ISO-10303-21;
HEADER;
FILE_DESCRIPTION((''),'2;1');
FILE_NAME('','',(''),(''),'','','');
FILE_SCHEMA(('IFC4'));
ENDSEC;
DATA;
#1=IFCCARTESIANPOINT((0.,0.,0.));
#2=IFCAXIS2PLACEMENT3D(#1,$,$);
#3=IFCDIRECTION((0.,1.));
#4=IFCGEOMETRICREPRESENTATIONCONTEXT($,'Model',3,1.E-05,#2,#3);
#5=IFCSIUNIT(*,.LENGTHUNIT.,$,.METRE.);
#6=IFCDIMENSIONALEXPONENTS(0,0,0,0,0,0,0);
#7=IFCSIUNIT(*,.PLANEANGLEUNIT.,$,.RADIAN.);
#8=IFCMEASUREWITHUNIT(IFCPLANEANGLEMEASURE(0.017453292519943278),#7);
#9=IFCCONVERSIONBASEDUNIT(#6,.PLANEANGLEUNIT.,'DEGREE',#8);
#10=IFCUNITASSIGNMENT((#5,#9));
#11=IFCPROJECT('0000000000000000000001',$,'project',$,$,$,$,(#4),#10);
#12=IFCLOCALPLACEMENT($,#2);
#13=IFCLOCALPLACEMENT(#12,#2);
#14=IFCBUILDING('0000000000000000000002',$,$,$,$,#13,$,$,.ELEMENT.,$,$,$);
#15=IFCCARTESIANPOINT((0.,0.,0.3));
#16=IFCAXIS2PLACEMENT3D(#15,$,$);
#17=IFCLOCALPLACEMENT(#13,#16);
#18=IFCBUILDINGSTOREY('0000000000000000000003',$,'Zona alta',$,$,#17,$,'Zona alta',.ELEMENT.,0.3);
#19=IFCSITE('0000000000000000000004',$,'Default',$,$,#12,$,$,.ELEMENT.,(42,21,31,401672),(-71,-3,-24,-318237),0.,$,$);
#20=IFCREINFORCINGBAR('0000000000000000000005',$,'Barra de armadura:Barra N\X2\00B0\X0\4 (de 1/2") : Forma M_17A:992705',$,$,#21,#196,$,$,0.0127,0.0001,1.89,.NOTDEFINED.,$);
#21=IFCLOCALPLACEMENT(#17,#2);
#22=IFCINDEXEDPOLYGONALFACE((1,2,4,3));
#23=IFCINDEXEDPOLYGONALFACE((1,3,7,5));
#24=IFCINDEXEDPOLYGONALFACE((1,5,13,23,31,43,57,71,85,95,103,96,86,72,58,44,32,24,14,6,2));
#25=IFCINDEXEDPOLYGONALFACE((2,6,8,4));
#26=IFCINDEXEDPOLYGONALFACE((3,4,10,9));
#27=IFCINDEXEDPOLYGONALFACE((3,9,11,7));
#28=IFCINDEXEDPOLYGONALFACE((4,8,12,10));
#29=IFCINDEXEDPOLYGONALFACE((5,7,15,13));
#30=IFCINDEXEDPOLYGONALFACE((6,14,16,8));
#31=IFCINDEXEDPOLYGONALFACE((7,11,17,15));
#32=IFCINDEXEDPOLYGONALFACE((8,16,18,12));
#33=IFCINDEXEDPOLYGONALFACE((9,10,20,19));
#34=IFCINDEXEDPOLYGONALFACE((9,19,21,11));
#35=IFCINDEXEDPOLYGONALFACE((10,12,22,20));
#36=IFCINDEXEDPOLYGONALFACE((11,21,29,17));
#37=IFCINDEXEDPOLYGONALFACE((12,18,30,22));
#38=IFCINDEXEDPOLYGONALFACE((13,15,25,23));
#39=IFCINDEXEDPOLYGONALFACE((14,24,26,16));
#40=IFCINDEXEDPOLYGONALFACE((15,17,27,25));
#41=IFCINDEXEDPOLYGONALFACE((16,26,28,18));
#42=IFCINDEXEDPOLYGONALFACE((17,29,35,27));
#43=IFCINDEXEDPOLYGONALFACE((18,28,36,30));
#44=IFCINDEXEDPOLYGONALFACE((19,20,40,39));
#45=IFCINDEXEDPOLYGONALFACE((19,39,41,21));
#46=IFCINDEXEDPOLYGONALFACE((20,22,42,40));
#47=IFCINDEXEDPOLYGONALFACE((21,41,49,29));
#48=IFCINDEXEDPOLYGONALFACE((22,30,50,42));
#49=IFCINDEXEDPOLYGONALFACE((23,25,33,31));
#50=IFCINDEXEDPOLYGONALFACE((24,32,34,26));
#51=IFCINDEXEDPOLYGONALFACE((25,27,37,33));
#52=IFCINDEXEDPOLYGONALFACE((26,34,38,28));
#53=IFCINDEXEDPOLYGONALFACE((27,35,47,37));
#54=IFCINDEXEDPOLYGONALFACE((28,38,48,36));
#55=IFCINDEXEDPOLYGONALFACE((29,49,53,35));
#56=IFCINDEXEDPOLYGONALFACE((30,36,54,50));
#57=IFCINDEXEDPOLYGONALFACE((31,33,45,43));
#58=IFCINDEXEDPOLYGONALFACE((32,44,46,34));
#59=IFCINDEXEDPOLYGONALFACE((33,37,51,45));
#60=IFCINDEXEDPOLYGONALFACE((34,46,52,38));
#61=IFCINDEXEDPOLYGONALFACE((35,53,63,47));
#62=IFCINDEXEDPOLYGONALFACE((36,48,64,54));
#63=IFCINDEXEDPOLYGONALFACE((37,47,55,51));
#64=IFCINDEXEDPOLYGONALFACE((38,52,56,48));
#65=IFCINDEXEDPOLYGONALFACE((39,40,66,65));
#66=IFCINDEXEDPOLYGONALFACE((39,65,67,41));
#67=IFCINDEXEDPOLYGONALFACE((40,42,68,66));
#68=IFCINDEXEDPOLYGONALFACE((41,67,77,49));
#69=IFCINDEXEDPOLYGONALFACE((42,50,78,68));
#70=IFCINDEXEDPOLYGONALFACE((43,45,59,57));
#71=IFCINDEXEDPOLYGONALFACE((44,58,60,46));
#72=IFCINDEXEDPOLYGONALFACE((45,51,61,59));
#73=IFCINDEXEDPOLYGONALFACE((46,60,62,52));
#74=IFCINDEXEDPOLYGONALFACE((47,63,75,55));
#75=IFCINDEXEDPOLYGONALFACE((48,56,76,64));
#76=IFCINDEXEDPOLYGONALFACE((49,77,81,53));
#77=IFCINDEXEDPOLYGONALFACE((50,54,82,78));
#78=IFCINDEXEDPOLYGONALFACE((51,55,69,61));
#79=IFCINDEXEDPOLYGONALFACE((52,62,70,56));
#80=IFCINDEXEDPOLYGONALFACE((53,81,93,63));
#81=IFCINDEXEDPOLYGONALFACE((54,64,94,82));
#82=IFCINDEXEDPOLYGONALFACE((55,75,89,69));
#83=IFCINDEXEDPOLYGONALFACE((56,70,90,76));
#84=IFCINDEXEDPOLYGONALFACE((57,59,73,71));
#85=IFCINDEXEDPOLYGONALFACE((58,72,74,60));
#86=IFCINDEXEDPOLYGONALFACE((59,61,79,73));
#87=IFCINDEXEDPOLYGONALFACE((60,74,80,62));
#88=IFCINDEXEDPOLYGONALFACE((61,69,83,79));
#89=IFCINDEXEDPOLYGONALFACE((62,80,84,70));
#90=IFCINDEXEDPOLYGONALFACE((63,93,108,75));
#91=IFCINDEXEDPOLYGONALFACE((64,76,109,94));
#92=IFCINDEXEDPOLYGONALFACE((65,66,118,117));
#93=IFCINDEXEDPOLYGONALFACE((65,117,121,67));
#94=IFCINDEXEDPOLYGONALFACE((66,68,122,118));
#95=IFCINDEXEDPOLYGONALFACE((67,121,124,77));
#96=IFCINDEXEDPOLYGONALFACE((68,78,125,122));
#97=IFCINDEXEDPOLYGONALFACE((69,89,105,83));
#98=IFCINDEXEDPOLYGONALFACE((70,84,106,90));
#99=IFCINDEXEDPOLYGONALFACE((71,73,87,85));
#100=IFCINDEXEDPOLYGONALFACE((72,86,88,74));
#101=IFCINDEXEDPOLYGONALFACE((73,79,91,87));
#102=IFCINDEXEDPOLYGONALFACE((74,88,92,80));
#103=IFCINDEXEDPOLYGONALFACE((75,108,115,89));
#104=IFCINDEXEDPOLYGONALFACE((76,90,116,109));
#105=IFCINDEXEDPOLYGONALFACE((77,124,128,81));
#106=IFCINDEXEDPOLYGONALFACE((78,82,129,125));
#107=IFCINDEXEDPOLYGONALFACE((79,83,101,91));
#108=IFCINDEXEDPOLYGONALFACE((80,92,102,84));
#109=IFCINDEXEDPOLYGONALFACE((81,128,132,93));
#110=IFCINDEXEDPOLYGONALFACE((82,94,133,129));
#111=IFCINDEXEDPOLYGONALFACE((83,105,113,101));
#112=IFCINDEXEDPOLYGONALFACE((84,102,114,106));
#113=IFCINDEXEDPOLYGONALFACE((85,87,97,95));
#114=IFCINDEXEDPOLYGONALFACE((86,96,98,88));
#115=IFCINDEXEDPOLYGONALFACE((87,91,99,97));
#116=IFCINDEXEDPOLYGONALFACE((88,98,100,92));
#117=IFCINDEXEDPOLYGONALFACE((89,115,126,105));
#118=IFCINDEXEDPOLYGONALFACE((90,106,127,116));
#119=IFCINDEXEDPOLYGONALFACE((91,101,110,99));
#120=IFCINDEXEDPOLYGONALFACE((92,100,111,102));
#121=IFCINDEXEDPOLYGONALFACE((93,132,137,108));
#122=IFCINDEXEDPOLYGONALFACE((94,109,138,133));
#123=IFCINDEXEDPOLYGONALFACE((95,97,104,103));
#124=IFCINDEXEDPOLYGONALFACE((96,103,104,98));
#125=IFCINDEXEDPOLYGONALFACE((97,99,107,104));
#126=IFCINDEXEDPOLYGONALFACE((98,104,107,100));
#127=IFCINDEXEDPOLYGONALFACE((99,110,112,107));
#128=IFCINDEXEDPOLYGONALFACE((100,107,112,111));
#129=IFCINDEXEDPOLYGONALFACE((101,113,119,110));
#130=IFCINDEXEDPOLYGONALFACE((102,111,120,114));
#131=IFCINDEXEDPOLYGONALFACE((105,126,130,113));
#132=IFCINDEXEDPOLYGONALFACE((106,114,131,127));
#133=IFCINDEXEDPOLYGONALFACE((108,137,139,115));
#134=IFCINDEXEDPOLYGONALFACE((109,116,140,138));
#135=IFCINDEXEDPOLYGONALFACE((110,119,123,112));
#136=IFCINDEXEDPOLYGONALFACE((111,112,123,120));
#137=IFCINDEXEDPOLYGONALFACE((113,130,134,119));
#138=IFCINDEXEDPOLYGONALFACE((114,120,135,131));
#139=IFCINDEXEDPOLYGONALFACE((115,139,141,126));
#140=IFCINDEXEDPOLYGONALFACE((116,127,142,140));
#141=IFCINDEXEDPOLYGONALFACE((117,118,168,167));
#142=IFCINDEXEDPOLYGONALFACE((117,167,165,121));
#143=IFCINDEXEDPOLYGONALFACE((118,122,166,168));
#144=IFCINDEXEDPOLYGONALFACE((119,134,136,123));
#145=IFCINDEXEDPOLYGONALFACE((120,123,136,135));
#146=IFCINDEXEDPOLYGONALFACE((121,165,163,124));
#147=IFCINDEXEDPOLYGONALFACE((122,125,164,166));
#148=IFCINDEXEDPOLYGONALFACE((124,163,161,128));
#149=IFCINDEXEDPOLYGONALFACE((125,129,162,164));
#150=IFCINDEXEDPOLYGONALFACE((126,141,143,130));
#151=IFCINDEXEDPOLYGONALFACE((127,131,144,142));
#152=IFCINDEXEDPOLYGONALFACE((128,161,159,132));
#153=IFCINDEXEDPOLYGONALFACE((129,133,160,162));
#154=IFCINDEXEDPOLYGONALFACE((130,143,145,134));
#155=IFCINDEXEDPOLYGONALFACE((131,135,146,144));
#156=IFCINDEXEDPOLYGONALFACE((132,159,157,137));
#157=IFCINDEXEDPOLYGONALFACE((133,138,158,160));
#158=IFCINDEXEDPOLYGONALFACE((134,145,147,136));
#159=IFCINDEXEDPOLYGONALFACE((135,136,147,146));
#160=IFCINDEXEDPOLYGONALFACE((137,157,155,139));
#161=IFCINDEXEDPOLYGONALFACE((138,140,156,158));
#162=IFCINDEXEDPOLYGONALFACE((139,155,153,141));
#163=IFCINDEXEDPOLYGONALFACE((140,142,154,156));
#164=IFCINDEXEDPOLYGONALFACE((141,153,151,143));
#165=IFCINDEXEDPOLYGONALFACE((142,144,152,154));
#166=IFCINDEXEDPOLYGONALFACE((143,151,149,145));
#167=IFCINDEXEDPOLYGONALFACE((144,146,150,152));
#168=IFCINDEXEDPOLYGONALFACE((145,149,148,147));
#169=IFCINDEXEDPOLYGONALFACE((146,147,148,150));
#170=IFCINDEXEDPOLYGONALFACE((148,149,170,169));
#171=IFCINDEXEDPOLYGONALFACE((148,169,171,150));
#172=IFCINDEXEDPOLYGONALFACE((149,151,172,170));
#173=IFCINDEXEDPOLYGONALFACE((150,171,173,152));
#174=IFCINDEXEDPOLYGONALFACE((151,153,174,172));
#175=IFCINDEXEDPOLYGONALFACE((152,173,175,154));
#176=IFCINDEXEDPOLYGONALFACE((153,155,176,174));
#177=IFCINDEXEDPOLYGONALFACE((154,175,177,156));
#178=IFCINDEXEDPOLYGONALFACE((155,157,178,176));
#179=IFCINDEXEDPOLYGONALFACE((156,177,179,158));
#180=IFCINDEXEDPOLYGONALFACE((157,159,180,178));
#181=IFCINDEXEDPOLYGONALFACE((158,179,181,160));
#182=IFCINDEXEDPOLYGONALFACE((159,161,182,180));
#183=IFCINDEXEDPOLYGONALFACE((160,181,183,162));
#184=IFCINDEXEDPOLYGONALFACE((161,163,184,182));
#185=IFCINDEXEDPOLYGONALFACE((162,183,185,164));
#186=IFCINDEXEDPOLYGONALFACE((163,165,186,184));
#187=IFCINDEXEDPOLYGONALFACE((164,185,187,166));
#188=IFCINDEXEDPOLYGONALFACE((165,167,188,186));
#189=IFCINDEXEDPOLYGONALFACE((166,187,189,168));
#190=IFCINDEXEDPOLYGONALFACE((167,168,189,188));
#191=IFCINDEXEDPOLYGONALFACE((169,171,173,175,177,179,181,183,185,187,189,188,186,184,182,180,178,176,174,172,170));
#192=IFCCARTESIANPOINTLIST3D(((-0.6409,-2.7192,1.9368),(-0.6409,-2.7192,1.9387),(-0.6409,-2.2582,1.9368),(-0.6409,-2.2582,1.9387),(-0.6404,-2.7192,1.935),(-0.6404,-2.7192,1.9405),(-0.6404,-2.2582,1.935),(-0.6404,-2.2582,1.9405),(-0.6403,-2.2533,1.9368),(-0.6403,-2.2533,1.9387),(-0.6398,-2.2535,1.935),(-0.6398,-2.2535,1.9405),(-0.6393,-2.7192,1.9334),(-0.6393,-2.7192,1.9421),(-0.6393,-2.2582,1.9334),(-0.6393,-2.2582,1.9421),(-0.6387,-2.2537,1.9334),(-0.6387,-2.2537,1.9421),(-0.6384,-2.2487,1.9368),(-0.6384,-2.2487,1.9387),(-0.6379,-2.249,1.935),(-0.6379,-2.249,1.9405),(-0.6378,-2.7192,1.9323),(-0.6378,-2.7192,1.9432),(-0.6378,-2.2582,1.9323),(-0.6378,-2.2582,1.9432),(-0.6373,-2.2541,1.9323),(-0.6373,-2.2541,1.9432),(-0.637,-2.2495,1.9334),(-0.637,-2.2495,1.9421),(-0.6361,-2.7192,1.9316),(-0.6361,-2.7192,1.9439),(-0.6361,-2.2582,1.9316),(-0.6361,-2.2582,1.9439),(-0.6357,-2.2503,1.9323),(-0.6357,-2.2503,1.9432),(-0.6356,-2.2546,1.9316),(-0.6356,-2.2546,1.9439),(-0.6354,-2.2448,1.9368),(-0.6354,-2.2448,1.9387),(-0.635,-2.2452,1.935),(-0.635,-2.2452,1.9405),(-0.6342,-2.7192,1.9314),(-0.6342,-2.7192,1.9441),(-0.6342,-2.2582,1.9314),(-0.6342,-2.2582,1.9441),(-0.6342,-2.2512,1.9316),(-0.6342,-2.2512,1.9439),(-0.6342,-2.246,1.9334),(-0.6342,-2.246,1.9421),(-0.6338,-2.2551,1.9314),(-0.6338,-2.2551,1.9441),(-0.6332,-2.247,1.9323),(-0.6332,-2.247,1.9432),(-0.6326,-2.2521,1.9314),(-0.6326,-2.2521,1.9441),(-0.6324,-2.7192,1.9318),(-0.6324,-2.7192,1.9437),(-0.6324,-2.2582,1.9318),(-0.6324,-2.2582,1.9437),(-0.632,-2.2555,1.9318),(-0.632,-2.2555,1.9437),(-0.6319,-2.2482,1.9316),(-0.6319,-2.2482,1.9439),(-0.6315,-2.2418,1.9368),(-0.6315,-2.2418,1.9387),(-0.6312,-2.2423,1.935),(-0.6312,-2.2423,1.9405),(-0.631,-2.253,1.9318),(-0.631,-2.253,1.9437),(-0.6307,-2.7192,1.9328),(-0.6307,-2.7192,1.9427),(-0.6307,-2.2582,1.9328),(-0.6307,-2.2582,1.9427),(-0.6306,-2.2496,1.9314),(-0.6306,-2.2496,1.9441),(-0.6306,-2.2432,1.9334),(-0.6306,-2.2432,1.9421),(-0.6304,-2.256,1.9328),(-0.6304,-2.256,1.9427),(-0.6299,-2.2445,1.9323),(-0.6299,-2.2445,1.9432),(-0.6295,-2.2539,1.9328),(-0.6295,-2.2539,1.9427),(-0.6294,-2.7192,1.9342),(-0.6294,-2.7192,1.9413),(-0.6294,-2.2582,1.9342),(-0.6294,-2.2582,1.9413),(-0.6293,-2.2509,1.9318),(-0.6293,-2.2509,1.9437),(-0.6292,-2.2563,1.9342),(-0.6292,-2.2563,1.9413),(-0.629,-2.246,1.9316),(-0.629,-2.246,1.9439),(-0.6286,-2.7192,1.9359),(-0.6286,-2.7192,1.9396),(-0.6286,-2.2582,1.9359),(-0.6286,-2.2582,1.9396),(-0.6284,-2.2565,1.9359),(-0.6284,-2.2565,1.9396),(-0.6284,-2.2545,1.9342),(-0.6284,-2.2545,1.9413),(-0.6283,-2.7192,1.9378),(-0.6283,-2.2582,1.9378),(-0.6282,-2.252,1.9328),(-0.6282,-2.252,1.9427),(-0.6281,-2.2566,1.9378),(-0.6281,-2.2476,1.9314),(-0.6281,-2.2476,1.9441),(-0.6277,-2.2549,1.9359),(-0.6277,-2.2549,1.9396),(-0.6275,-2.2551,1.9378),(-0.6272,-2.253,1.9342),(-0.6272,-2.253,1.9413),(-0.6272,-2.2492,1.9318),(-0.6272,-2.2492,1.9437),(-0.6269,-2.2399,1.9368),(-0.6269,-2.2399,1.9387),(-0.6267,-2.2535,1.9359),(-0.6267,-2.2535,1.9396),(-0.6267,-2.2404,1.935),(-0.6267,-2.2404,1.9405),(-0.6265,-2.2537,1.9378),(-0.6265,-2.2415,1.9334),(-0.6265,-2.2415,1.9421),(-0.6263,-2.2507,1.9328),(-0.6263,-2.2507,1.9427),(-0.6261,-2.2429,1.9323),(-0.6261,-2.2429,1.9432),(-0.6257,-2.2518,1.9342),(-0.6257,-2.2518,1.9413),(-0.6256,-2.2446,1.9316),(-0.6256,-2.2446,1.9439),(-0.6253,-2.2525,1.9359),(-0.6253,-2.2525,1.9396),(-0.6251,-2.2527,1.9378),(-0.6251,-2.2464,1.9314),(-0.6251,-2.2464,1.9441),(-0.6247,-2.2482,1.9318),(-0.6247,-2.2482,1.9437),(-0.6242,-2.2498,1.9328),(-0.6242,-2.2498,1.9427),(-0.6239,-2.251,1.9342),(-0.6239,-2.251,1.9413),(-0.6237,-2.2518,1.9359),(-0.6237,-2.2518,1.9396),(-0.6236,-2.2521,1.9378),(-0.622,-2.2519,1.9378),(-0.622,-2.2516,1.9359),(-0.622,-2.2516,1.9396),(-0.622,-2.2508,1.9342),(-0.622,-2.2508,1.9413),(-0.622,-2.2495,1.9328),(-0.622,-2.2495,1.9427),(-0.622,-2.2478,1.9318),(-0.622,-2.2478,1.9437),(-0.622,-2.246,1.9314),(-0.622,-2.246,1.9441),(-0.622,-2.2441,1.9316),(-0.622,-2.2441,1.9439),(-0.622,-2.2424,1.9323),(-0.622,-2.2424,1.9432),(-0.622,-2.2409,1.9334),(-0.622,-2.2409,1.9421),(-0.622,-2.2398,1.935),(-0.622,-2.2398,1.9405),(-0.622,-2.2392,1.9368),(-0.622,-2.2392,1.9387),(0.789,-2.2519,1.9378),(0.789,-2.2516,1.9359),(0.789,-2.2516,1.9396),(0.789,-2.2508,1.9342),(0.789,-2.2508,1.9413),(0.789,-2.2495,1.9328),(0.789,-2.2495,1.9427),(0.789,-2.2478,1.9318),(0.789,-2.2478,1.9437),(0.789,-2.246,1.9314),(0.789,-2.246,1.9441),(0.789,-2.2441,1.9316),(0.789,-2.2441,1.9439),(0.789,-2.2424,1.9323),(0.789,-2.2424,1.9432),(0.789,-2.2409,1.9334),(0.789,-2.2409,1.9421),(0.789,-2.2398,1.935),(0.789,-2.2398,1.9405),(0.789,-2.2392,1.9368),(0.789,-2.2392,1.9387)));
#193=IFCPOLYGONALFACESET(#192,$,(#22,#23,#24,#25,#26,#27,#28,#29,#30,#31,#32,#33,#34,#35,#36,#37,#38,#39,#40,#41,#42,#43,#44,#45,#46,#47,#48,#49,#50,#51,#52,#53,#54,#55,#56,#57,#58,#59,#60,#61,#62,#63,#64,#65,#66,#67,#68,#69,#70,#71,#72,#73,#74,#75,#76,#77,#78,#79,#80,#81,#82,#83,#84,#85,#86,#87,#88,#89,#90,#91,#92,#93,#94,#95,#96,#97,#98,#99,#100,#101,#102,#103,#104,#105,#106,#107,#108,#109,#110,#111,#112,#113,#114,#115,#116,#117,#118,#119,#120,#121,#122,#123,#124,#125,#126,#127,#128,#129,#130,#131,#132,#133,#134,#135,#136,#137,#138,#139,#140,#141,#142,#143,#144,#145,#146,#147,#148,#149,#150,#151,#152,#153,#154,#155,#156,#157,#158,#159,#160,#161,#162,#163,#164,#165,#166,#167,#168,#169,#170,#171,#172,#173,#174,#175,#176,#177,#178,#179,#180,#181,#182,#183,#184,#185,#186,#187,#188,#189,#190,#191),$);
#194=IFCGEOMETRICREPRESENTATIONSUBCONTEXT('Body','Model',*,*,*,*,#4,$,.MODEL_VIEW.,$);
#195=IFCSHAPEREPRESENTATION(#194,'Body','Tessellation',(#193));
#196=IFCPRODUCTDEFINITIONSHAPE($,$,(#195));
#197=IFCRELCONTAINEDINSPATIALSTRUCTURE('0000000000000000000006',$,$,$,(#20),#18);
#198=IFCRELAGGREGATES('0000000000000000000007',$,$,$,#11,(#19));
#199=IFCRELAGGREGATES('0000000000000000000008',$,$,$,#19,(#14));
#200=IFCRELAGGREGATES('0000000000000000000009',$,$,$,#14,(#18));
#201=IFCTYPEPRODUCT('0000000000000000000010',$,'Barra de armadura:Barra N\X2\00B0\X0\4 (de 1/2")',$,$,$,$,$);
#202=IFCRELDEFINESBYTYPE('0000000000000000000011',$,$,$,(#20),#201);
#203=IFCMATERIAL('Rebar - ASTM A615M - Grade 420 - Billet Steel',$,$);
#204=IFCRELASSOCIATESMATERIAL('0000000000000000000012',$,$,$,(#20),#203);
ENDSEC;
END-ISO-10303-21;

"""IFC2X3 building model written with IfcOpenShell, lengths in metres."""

from ifc_helpers import new_model, entity, si_unit, converted_unit, direction, frame, origin, place, context, subcontext, project, spatial, material, type_object, element, save


model = new_model("IFC2X3")

# Units and contexts
model_context = context("Model", 3, precision=1e-05, world=origin(), true_north=direction((0.0, 1.0)))
body_context = subcontext(model_context, "Body", "Model", "MODEL_VIEW")
ifc_project = project(units=[si_unit("LENGTHUNIT", "METRE"), converted_unit("PLANEANGLEUNIT", "DEGREE", entity("IfcPlaneAngleMeasure", 0.017453292519943278), si_unit("PLANEANGLEUNIT", "RADIAN"), dimensions=[0, 0, 0, 0, 0, 0, 0])], contexts=[model_context])

# Site, building, storey
site_placement = place(None, origin())
site = spatial("IfcSite", under=ifc_project, at=site_placement, Name="Default", CompositionType="ELEMENT", RefLatitude=(42, 21, 31, 401672), RefLongitude=(-71, -3, -24, -318237), RefElevation=0.0)
building_placement = place(site_placement, origin())
building = spatial("IfcBuilding", under=site, at=building_placement, CompositionType="ELEMENT")
storey_placement = place(building_placement, frame((0.0, 0.0, 0.3)))
storey = spatial("IfcBuildingStorey", under=building, at=storey_placement, Name="Zona alta", LongName="Zona alta", CompositionType="ELEMENT", Elevation=0.3)

# Reinforcing bar
ifc_material_1 = material(Name="Rebar - ASTM A615M - Grade 420 - Billet Steel")
type_product_1 = type_object("IfcTypeProduct", Name="Barra de armadura:Barra N°4 (de 1/2\")")
reinforcing_bar_1_placement = place(storey_placement, origin())
element("IfcReinforcingBar", 1, at=reinforcing_bar_1_placement, inside=storey, type_object=type_product_1, material=ifc_material_1, Name="Barra de armadura:Barra N°4 (de 1/2\") : Forma M_17A:992705", BarLength=1.89, BarRole="NOTDEFINED", CrossSectionArea=0.0001, NominalDiameter=0.0127, context=body_context, shape_type="AdvancedSweptSolid", body=[
    entity("IfcSweptDiskSolid", entity("IfcCompositeCurve", [entity("IfcCompositeCurveSegment", "CONTINUOUS", True, entity("IfcPolyline", [entity("IfcCartesianPoint", [0.789, -2.2455, 1.9378]), entity("IfcCartesianPoint", [-0.622, -2.2455, 1.9378])])), entity("IfcCompositeCurveSegment", "CONTINUOUS", True, entity("IfcTrimmedCurve", entity("IfcCircle", entity("IfcAxis2Placement3D", entity("IfcCartesianPoint", [-0.622, -2.2582, 1.9378]), entity("IfcDirection", [0.0, 0.0, 1.0]), entity("IfcDirection", [-1.0, 0.0, 0.0])), 0.0127), [entity("IfcParameterValue", 270.0)], [entity("IfcParameterValue", 360.0)], True, "PARAMETER")), entity("IfcCompositeCurveSegment", "CONTINUOUS", True, entity("IfcPolyline", [entity("IfcCartesianPoint", [-0.6347, -2.2582, 1.9378]), entity("IfcCartesianPoint", [-0.6347, -2.7192, 1.9378])]))], False), 0.0063, None, 0.0, 92.0),
])

save(model, "model.ifc")
